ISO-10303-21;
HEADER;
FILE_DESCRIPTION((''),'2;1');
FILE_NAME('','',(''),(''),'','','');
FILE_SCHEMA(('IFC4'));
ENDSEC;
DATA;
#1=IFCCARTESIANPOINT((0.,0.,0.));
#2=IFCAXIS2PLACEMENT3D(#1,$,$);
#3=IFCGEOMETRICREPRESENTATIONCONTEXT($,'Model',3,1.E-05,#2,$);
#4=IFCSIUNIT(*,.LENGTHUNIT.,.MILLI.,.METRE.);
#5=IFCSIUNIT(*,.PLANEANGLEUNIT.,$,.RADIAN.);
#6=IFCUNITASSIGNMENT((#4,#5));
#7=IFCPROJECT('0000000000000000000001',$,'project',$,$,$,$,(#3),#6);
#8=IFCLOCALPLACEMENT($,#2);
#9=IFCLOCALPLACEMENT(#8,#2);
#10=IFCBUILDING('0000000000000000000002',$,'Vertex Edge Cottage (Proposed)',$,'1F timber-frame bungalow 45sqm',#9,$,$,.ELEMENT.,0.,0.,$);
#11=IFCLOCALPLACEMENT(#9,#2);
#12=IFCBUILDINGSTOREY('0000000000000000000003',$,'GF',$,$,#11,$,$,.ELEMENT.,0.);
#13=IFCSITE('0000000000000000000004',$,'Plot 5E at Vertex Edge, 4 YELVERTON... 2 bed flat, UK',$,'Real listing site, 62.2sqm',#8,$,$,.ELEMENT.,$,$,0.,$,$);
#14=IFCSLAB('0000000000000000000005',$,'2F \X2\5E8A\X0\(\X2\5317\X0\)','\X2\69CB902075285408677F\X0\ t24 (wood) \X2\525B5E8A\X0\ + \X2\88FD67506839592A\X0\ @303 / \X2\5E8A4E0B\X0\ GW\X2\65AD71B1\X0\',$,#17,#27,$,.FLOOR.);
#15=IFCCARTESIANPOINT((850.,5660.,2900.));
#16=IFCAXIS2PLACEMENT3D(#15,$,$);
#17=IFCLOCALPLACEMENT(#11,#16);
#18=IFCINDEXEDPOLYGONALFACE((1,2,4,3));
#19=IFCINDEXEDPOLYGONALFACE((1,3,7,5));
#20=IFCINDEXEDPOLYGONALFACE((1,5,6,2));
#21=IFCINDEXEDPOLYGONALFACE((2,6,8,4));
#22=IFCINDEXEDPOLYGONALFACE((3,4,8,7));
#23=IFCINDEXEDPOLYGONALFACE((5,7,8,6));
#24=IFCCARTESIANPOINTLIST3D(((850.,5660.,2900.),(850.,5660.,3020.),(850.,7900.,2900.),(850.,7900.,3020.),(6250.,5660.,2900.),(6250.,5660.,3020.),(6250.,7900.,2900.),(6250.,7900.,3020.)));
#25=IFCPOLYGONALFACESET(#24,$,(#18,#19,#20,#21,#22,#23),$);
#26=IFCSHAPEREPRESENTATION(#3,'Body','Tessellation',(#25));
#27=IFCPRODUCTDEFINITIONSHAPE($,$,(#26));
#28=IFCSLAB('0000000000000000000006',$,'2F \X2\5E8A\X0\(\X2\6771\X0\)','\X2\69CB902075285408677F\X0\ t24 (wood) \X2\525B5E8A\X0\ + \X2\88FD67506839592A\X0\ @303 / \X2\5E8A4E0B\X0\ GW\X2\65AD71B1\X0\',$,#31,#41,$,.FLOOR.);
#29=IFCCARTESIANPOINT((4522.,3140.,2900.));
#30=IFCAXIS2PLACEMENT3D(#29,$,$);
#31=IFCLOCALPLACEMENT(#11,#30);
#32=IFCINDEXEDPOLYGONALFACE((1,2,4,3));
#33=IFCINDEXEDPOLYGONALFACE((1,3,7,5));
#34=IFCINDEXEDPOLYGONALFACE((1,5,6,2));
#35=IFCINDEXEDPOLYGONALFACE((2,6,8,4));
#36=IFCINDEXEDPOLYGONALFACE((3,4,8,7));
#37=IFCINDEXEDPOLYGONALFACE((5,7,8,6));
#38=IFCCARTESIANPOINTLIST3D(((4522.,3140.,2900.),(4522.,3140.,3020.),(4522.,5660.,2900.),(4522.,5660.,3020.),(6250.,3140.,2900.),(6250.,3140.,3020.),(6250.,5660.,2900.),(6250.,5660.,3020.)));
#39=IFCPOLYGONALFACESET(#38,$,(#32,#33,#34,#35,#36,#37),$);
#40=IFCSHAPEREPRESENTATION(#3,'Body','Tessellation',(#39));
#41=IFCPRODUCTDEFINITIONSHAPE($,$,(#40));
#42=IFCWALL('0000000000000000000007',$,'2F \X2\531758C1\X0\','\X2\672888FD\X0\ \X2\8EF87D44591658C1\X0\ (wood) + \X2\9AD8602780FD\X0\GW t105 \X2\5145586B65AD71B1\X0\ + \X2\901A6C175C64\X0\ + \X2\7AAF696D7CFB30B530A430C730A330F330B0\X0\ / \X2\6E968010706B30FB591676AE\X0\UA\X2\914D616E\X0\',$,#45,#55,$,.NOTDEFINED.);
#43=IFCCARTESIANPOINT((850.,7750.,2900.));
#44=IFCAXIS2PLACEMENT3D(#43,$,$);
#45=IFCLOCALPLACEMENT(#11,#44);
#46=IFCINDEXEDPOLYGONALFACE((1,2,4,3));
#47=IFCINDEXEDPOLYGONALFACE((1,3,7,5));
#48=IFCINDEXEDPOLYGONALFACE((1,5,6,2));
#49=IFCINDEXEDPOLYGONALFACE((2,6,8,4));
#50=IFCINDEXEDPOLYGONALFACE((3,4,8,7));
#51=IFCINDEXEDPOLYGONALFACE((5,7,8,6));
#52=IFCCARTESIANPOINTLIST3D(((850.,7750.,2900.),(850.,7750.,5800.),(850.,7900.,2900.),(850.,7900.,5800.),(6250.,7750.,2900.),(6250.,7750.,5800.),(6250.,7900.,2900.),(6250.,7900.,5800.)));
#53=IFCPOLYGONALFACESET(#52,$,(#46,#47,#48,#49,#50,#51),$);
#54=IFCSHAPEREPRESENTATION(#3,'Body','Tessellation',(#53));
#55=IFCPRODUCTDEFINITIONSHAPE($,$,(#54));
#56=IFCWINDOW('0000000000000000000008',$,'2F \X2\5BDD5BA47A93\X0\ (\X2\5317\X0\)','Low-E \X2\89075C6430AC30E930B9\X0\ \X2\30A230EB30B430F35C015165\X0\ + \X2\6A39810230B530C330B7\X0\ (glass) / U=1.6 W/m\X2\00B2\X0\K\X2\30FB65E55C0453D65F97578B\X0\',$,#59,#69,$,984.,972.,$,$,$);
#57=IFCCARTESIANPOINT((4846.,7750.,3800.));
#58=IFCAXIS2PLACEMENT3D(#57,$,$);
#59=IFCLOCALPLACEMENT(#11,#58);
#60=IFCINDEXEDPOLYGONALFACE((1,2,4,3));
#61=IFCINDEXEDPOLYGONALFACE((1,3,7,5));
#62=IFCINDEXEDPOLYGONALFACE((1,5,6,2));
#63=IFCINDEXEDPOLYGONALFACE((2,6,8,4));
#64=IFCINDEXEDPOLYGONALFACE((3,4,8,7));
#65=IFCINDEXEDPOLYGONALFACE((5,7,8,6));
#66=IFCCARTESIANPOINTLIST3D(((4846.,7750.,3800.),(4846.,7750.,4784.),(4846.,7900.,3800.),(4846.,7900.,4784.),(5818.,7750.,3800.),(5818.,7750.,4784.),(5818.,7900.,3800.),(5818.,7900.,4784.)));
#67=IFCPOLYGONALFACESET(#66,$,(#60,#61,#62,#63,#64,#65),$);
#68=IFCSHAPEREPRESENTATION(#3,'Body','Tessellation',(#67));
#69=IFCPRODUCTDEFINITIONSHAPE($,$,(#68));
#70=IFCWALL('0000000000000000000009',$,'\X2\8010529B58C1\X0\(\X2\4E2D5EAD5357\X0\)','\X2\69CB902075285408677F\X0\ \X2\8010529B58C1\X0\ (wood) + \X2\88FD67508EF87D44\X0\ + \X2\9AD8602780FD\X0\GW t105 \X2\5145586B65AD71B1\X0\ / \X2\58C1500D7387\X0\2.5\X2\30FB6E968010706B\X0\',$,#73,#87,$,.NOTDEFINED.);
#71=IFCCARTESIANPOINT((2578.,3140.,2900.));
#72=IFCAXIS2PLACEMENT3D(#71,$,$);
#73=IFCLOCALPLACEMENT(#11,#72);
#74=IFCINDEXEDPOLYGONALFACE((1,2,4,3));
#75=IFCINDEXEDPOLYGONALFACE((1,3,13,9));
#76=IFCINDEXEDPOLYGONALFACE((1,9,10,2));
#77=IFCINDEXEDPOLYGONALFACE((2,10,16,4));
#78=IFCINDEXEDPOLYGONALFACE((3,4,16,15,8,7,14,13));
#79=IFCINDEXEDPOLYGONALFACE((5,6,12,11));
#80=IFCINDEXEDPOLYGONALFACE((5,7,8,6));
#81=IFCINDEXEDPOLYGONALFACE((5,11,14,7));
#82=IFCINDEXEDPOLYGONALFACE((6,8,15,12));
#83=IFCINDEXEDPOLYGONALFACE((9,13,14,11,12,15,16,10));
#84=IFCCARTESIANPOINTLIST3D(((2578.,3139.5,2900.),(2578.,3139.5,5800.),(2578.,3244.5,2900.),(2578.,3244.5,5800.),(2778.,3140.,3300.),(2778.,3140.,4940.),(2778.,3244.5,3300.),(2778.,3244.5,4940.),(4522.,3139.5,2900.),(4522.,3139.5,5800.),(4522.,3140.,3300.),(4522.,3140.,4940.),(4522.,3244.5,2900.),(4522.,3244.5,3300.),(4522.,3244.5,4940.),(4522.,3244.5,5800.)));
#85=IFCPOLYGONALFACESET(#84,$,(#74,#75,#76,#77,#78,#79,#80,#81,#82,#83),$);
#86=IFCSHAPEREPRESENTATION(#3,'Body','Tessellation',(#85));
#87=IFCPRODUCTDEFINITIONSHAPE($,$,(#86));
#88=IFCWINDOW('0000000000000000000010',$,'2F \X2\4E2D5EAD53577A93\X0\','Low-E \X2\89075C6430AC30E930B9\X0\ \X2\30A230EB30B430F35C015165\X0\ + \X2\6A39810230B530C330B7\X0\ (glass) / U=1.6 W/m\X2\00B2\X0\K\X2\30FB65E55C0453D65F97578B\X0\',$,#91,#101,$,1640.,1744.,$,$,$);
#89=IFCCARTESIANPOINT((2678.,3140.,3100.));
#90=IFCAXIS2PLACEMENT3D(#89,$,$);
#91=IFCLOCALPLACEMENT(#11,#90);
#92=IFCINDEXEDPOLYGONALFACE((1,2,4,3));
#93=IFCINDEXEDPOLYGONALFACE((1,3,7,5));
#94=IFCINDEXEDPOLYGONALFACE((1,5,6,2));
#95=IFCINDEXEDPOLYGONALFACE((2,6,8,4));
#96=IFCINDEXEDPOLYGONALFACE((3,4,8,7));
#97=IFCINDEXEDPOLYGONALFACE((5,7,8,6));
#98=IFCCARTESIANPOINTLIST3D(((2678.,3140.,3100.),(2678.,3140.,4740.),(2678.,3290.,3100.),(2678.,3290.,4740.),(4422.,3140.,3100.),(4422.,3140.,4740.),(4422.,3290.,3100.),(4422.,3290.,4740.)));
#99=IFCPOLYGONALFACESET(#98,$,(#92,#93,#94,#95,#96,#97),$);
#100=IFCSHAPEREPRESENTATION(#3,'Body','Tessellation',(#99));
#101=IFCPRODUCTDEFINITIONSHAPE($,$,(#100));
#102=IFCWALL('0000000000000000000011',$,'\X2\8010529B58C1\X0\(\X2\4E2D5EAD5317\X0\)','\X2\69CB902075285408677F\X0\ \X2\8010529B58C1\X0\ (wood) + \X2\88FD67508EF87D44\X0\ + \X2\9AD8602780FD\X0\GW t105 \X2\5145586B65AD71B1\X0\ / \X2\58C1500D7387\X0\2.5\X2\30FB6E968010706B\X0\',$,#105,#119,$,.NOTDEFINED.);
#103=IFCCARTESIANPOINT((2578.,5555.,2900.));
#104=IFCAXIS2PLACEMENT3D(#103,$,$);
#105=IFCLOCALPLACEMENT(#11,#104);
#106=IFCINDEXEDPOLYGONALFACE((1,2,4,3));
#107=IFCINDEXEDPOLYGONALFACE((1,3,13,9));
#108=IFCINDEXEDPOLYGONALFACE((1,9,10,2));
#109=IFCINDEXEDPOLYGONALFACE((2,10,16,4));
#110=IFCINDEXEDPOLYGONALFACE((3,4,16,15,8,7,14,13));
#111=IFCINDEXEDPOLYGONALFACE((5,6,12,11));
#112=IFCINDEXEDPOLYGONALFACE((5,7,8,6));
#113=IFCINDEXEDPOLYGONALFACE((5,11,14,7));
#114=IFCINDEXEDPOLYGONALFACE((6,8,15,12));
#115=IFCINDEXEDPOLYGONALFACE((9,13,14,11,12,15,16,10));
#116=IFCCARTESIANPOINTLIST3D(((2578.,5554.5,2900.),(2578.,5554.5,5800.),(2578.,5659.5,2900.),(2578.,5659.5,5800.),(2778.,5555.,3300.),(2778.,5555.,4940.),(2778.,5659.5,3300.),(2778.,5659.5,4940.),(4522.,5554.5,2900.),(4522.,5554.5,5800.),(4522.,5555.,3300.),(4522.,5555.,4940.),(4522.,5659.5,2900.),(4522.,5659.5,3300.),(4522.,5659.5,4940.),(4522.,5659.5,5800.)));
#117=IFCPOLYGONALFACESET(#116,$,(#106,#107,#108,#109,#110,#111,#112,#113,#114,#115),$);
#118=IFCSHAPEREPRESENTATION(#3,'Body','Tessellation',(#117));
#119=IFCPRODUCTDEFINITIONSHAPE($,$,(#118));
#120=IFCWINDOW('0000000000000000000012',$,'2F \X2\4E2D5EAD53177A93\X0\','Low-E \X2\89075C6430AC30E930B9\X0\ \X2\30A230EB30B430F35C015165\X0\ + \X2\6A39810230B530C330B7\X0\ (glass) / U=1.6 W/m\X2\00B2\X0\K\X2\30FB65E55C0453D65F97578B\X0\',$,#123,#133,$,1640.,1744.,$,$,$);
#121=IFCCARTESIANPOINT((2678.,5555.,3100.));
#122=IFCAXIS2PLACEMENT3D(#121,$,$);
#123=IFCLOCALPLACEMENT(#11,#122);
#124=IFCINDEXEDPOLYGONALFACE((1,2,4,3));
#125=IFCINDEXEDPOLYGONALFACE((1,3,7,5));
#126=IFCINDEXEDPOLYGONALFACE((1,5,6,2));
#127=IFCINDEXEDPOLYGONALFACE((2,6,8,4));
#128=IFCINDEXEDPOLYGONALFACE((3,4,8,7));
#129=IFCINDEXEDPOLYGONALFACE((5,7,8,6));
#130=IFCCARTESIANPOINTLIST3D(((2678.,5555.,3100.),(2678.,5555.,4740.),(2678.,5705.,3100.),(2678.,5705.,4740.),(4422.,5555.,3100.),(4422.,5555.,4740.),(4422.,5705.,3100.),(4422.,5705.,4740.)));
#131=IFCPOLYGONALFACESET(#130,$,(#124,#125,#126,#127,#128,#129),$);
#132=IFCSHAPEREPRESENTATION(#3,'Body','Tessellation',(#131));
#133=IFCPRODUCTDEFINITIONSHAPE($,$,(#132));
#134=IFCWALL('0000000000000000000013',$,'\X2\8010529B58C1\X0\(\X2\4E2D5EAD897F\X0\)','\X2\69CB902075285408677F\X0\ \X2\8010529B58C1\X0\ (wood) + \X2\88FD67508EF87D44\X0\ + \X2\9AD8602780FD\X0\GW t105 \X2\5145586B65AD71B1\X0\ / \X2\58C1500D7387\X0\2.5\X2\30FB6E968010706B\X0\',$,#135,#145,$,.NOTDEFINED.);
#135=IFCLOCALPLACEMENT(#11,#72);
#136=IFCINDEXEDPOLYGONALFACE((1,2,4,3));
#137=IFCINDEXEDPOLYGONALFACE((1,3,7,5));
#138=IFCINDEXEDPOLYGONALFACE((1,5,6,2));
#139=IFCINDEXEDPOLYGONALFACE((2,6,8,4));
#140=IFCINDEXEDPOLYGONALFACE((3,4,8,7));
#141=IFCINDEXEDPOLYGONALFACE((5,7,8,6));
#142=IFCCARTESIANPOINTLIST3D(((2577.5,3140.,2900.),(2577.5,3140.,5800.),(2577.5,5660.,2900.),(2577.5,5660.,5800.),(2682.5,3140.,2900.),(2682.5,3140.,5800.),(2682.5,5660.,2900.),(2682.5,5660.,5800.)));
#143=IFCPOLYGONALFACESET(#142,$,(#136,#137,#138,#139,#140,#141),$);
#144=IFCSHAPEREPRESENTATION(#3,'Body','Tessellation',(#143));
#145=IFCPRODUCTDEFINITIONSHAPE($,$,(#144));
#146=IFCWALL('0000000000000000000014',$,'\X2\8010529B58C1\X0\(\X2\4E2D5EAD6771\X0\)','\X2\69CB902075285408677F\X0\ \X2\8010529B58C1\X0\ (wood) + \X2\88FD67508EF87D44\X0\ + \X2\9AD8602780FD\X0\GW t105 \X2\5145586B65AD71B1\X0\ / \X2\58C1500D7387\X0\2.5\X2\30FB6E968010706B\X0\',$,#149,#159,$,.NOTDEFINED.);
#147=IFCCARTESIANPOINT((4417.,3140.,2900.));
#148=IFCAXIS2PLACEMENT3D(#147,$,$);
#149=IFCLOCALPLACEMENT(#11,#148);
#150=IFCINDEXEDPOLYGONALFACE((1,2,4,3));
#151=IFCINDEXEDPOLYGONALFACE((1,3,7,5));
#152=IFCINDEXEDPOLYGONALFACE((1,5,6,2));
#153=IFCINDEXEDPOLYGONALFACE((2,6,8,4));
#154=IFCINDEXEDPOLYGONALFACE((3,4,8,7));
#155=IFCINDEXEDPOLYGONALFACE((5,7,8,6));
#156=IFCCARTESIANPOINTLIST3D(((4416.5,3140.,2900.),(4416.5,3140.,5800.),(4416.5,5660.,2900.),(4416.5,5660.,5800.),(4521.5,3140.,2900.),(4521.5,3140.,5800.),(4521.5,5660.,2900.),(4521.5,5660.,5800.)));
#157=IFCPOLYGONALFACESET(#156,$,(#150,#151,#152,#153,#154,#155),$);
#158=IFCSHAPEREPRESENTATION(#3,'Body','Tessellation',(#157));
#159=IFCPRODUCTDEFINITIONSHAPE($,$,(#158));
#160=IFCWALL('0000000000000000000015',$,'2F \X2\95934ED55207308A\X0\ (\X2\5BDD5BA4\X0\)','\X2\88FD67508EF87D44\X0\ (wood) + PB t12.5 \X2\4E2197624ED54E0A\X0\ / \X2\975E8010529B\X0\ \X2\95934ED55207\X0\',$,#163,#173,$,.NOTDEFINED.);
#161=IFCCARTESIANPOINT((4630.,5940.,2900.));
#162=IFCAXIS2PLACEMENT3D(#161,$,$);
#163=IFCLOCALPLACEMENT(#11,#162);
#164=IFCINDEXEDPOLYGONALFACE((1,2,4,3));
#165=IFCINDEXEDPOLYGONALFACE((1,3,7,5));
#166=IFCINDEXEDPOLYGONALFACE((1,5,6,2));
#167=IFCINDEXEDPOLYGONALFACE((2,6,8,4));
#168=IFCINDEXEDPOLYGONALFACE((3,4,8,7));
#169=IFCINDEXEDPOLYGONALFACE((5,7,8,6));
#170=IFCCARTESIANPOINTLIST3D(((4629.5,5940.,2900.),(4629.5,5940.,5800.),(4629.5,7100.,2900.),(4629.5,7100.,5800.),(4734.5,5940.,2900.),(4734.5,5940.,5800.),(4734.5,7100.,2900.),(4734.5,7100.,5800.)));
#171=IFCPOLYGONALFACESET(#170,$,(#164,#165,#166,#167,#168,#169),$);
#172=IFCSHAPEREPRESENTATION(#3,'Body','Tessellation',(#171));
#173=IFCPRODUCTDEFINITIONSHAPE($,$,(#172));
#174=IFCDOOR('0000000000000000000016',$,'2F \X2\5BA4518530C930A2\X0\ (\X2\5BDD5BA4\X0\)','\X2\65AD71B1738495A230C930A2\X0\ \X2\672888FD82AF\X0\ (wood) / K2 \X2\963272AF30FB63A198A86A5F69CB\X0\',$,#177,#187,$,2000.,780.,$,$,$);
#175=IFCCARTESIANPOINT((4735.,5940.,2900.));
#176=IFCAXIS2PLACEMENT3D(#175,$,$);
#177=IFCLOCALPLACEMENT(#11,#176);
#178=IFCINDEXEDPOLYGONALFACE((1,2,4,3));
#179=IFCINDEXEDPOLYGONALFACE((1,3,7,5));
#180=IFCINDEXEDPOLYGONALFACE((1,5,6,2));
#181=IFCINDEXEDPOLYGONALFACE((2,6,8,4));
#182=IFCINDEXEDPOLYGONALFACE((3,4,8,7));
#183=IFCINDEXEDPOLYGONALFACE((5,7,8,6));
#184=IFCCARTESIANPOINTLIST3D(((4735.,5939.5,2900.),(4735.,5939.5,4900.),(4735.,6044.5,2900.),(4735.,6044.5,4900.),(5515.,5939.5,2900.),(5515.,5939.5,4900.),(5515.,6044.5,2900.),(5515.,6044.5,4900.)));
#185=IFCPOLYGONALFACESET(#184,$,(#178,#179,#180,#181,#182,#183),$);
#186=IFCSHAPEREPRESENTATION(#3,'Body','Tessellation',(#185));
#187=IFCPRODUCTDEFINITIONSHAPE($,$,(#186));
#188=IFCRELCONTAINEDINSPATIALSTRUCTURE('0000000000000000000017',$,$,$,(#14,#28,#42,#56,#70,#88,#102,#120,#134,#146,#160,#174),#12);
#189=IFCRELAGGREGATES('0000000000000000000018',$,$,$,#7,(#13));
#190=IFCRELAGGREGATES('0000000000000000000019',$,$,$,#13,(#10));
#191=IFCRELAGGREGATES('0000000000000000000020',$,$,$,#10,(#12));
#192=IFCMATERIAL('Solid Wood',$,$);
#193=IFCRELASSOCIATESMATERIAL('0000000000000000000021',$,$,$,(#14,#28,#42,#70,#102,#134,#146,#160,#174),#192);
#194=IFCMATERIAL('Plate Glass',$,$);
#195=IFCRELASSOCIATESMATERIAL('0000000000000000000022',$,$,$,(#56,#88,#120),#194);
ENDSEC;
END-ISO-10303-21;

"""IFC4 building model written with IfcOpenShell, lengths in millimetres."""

from ifc_helpers import new_model, si_unit, frame, frame_2d, origin, place, context, project, spatial, rectangle, extrude, material, element, fill, save


model = new_model("IFC4")

# Units and contexts
model_context = context("Model", 3, precision=1e-05, world=origin())
ifc_project = project(units=[si_unit("LENGTHUNIT", "METRE", prefix="MILLI"), si_unit("PLANEANGLEUNIT", "RADIAN")], contexts=[model_context])

# Site, building, storey
site_placement = place(None, origin())
site = spatial("IfcSite", under=ifc_project, at=site_placement, Name="Plot 5E at Vertex Edge, 4 YELVERTON... 2 bed flat, UK", ObjectType="Real listing site, 62.2sqm", CompositionType="ELEMENT", RefElevation=0.0)
building_placement = place(site_placement, origin())
building = spatial("IfcBuilding", under=site, at=building_placement, Name="Vertex Edge Cottage (Proposed)", ObjectType="1F timber-frame bungalow 45sqm", CompositionType="ELEMENT", ElevationOfRefHeight=0.0, ElevationOfTerrain=0.0)
storey_placement = place(building_placement, origin())
storey = spatial("IfcBuildingStorey", under=building, at=storey_placement, Name="GF", CompositionType="ELEMENT", Elevation=0.0)

# Slabs
ifc_material_1 = material(Name="Solid Wood")
slab_1_placement = place(storey_placement, frame((850.0, 5660.0, 2900.0)))
element("IfcSlab", 1, at=slab_1_placement, inside=storey, material=ifc_material_1, Name="2F 床(北)", Description="構造用合板 t24 (wood) 剛床 + 製材根太 @303 / 床下 GW断熱", PredefinedType="FLOOR", context=model_context, shape_type="SweptSolid", body=[
    extrude(rectangle(XDim=5400.0, YDim=2240.0, at=frame_2d((2700.0, 1120.0))), frame((850.0, 5660.0, 2900.0)), (0.0, 0.0, 1.0), 120.0),
])
slab_2_placement = place(storey_placement, frame((4522.0, 3140.0, 2900.0)))
element("IfcSlab", 2, at=slab_2_placement, inside=storey, material=ifc_material_1, Name="2F 床(東)", Description="構造用合板 t24 (wood) 剛床 + 製材根太 @303 / 床下 GW断熱", PredefinedType="FLOOR", context=model_context, shape_type="SweptSolid", body=[
    extrude(rectangle(XDim=1728.0, YDim=2520.0, at=frame_2d((864.0, 1260.0))), frame((4522.0, 3140.0, 2900.0)), (0.0, 0.0, 1.0), 120.0),
])

# Walls, openings, windows
wall_1_placement = place(storey_placement, frame((850.0, 7750.0, 2900.0)))
wall_1 = element("IfcWall", 3, at=wall_1_placement, inside=storey, material=ifc_material_1, Name="2F 北壁", Description="木製 軸組外壁 (wood) + 高性能GW t105 充填断熱 + 通気層 + 窯業系サイディング / 準耐火・外皮UA配慮", PredefinedType="NOTDEFINED", context=model_context, shape_type="SweptSolid", body=[
    extrude(rectangle(XDim=5400.0, YDim=150.0, at=frame_2d((2700.0, 75.0))), frame((850.0, 7750.0, 2900.0)), (0.0, 0.0, 1.0), 2900.0),
])
opening_1_placement = place(storey_placement, frame((4846.0, 7750.0, 3800.0)))
opening_1 = element("IfcOpeningElement", 4, at=opening_1_placement, cuts=wall_1, PredefinedType="NOTDEFINED", context=model_context, shape_type="SweptSolid", body=[
    extrude(rectangle(XDim=972.0, YDim=150.0, at=frame_2d((486.0, 75.0))), frame((4846.0, 7750.0, 3800.0)), (0.0, 0.0, 1.0), 984.0),
])
ifc_material_2 = material(Name="Plate Glass")
window_1_placement = place(storey_placement, frame((4846.0, 7750.0, 3800.0)))
window_1 = element("IfcWindow", 5, at=window_1_placement, inside=storey, material=ifc_material_2, Name="2F 寝室窓 (北)", Description="Low-E 複層ガラス アルゴン封入 + 樹脂サッシ (glass) / U=1.6 W/m²K・日射取得型", OverallHeight=984.0, OverallWidth=972.0, context=model_context, shape_type="SweptSolid", body=[
    extrude(rectangle(XDim=972.0, YDim=150.0, at=frame_2d((486.0, 75.0))), frame((4846.0, 7750.0, 3800.0)), (0.0, 0.0, 1.0), 984.0),
])
fill(opening_1, window_1)
wall_2_placement = place(storey_placement, frame((2578.0, 3140.0, 2900.0)))
wall_2 = element("IfcWall", 6, at=wall_2_placement, inside=storey, material=ifc_material_1, Name="耐力壁(中庭南)", Description="構造用合板 耐力壁 (wood) + 製材軸組 + 高性能GW t105 充填断熱 / 壁倍率2.5・準耐火", PredefinedType="NOTDEFINED", context=model_context, shape_type="SweptSolid", body=[
    extrude(rectangle(XDim=1944.0, YDim=105.0, at=frame_2d((972.0, 52.0))), frame((2578.0, 3140.0, 2900.0)), (0.0, 0.0, 1.0), 2900.0),
])
opening_2_placement = place(storey_placement, frame((2678.0, 3140.0, 3100.0)))
opening_2 = element("IfcOpeningElement", 7, at=opening_2_placement, cuts=wall_2, PredefinedType="NOTDEFINED", context=model_context, shape_type="SweptSolid", body=[
    extrude(rectangle(XDim=1744.0, YDim=150.0, at=frame_2d((872.0, 75.0))), frame((2678.0, 3140.0, 3100.0)), (0.0, 0.0, 1.0), 1640.0),
])
window_2_placement = place(storey_placement, frame((2678.0, 3140.0, 3100.0)))
window_2 = element("IfcWindow", 8, at=window_2_placement, inside=storey, material=ifc_material_2, Name="2F 中庭南窓", Description="Low-E 複層ガラス アルゴン封入 + 樹脂サッシ (glass) / U=1.6 W/m²K・日射取得型", OverallHeight=1640.0, OverallWidth=1744.0, context=model_context, shape_type="SweptSolid", body=[
    extrude(rectangle(XDim=1744.0, YDim=150.0, at=frame_2d((872.0, 75.0))), frame((2678.0, 3140.0, 3100.0)), (0.0, 0.0, 1.0), 1640.0),
])
fill(opening_2, window_2)
wall_3_placement = place(storey_placement, frame((2578.0, 5555.0, 2900.0)))
wall_3 = element("IfcWall", 9, at=wall_3_placement, inside=storey, material=ifc_material_1, Name="耐力壁(中庭北)", Description="構造用合板 耐力壁 (wood) + 製材軸組 + 高性能GW t105 充填断熱 / 壁倍率2.5・準耐火", PredefinedType="NOTDEFINED", context=model_context, shape_type="SweptSolid", body=[
    extrude(rectangle(XDim=1944.0, YDim=105.0, at=frame_2d((972.0, 52.0))), frame((2578.0, 5555.0, 2900.0)), (0.0, 0.0, 1.0), 2900.0),
])
opening_3_placement = place(storey_placement, frame((2678.0, 5555.0, 3100.0)))
opening_3 = element("IfcOpeningElement", 10, at=opening_3_placement, cuts=wall_3, PredefinedType="NOTDEFINED", context=model_context, shape_type="SweptSolid", body=[
    extrude(rectangle(XDim=1744.0, YDim=150.0, at=frame_2d((872.0, 75.0))), frame((2678.0, 5555.0, 3100.0)), (0.0, 0.0, 1.0), 1640.0),
])
window_3_placement = place(storey_placement, frame((2678.0, 5555.0, 3100.0)))
window_3 = element("IfcWindow", 11, at=window_3_placement, inside=storey, material=ifc_material_2, Name="2F 中庭北窓", Description="Low-E 複層ガラス アルゴン封入 + 樹脂サッシ (glass) / U=1.6 W/m²K・日射取得型", OverallHeight=1640.0, OverallWidth=1744.0, context=model_context, shape_type="SweptSolid", body=[
    extrude(rectangle(XDim=1744.0, YDim=150.0, at=frame_2d((872.0, 75.0))), frame((2678.0, 5555.0, 3100.0)), (0.0, 0.0, 1.0), 1640.0),
])
fill(opening_3, window_3)

# Walls
wall_4_placement = place(storey_placement, frame((2578.0, 3140.0, 2900.0)))
element("IfcWall", 12, at=wall_4_placement, inside=storey, material=ifc_material_1, Name="耐力壁(中庭西)", Description="構造用合板 耐力壁 (wood) + 製材軸組 + 高性能GW t105 充填断熱 / 壁倍率2.5・準耐火", PredefinedType="NOTDEFINED", context=model_context, shape_type="SweptSolid", body=[
    extrude(rectangle(XDim=105.0, YDim=2520.0, at=frame_2d((52.0, 1260.0))), frame((2578.0, 3140.0, 2900.0)), (0.0, 0.0, 1.0), 2900.0),
])
wall_5_placement = place(storey_placement, frame((4417.0, 3140.0, 2900.0)))
element("IfcWall", 13, at=wall_5_placement, inside=storey, material=ifc_material_1, Name="耐力壁(中庭東)", Description="構造用合板 耐力壁 (wood) + 製材軸組 + 高性能GW t105 充填断熱 / 壁倍率2.5・準耐火", PredefinedType="NOTDEFINED", context=model_context, shape_type="SweptSolid", body=[
    extrude(rectangle(XDim=105.0, YDim=2520.0, at=frame_2d((52.0, 1260.0))), frame((4417.0, 3140.0, 2900.0)), (0.0, 0.0, 1.0), 2900.0),
])
wall_6_placement = place(storey_placement, frame((4630.0, 5940.0, 2900.0)))
element("IfcWall", 14, at=wall_6_placement, inside=storey, material=ifc_material_1, Name="2F 間仕切り (寝室)", Description="製材軸組 (wood) + PB t12.5 両面仕上 / 非耐力 間仕切", PredefinedType="NOTDEFINED", context=model_context, shape_type="SweptSolid", body=[
    extrude(rectangle(XDim=105.0, YDim=1160.0, at=frame_2d((52.0, 580.0))), frame((4630.0, 5940.0, 2900.0)), (0.0, 0.0, 1.0), 2900.0),
])

# Door
door_placement = place(storey_placement, frame((4735.0, 5940.0, 2900.0)))
element("IfcDoor", 15, at=door_placement, inside=storey, material=ifc_material_1, Name="2F 室内ドア (寝室)", Description="断熱玄関ドア 木製芯 (wood) / K2 防犯・採風機構", OverallHeight=2000.0, OverallWidth=780.0, context=model_context, shape_type="SweptSolid", body=[
    extrude(rectangle(XDim=780.0, YDim=105.0, at=frame_2d((390.0, 52.0))), frame((4735.0, 5940.0, 2900.0)), (0.0, 0.0, 1.0), 2000.0),
])

save(model, "model.ifc")
